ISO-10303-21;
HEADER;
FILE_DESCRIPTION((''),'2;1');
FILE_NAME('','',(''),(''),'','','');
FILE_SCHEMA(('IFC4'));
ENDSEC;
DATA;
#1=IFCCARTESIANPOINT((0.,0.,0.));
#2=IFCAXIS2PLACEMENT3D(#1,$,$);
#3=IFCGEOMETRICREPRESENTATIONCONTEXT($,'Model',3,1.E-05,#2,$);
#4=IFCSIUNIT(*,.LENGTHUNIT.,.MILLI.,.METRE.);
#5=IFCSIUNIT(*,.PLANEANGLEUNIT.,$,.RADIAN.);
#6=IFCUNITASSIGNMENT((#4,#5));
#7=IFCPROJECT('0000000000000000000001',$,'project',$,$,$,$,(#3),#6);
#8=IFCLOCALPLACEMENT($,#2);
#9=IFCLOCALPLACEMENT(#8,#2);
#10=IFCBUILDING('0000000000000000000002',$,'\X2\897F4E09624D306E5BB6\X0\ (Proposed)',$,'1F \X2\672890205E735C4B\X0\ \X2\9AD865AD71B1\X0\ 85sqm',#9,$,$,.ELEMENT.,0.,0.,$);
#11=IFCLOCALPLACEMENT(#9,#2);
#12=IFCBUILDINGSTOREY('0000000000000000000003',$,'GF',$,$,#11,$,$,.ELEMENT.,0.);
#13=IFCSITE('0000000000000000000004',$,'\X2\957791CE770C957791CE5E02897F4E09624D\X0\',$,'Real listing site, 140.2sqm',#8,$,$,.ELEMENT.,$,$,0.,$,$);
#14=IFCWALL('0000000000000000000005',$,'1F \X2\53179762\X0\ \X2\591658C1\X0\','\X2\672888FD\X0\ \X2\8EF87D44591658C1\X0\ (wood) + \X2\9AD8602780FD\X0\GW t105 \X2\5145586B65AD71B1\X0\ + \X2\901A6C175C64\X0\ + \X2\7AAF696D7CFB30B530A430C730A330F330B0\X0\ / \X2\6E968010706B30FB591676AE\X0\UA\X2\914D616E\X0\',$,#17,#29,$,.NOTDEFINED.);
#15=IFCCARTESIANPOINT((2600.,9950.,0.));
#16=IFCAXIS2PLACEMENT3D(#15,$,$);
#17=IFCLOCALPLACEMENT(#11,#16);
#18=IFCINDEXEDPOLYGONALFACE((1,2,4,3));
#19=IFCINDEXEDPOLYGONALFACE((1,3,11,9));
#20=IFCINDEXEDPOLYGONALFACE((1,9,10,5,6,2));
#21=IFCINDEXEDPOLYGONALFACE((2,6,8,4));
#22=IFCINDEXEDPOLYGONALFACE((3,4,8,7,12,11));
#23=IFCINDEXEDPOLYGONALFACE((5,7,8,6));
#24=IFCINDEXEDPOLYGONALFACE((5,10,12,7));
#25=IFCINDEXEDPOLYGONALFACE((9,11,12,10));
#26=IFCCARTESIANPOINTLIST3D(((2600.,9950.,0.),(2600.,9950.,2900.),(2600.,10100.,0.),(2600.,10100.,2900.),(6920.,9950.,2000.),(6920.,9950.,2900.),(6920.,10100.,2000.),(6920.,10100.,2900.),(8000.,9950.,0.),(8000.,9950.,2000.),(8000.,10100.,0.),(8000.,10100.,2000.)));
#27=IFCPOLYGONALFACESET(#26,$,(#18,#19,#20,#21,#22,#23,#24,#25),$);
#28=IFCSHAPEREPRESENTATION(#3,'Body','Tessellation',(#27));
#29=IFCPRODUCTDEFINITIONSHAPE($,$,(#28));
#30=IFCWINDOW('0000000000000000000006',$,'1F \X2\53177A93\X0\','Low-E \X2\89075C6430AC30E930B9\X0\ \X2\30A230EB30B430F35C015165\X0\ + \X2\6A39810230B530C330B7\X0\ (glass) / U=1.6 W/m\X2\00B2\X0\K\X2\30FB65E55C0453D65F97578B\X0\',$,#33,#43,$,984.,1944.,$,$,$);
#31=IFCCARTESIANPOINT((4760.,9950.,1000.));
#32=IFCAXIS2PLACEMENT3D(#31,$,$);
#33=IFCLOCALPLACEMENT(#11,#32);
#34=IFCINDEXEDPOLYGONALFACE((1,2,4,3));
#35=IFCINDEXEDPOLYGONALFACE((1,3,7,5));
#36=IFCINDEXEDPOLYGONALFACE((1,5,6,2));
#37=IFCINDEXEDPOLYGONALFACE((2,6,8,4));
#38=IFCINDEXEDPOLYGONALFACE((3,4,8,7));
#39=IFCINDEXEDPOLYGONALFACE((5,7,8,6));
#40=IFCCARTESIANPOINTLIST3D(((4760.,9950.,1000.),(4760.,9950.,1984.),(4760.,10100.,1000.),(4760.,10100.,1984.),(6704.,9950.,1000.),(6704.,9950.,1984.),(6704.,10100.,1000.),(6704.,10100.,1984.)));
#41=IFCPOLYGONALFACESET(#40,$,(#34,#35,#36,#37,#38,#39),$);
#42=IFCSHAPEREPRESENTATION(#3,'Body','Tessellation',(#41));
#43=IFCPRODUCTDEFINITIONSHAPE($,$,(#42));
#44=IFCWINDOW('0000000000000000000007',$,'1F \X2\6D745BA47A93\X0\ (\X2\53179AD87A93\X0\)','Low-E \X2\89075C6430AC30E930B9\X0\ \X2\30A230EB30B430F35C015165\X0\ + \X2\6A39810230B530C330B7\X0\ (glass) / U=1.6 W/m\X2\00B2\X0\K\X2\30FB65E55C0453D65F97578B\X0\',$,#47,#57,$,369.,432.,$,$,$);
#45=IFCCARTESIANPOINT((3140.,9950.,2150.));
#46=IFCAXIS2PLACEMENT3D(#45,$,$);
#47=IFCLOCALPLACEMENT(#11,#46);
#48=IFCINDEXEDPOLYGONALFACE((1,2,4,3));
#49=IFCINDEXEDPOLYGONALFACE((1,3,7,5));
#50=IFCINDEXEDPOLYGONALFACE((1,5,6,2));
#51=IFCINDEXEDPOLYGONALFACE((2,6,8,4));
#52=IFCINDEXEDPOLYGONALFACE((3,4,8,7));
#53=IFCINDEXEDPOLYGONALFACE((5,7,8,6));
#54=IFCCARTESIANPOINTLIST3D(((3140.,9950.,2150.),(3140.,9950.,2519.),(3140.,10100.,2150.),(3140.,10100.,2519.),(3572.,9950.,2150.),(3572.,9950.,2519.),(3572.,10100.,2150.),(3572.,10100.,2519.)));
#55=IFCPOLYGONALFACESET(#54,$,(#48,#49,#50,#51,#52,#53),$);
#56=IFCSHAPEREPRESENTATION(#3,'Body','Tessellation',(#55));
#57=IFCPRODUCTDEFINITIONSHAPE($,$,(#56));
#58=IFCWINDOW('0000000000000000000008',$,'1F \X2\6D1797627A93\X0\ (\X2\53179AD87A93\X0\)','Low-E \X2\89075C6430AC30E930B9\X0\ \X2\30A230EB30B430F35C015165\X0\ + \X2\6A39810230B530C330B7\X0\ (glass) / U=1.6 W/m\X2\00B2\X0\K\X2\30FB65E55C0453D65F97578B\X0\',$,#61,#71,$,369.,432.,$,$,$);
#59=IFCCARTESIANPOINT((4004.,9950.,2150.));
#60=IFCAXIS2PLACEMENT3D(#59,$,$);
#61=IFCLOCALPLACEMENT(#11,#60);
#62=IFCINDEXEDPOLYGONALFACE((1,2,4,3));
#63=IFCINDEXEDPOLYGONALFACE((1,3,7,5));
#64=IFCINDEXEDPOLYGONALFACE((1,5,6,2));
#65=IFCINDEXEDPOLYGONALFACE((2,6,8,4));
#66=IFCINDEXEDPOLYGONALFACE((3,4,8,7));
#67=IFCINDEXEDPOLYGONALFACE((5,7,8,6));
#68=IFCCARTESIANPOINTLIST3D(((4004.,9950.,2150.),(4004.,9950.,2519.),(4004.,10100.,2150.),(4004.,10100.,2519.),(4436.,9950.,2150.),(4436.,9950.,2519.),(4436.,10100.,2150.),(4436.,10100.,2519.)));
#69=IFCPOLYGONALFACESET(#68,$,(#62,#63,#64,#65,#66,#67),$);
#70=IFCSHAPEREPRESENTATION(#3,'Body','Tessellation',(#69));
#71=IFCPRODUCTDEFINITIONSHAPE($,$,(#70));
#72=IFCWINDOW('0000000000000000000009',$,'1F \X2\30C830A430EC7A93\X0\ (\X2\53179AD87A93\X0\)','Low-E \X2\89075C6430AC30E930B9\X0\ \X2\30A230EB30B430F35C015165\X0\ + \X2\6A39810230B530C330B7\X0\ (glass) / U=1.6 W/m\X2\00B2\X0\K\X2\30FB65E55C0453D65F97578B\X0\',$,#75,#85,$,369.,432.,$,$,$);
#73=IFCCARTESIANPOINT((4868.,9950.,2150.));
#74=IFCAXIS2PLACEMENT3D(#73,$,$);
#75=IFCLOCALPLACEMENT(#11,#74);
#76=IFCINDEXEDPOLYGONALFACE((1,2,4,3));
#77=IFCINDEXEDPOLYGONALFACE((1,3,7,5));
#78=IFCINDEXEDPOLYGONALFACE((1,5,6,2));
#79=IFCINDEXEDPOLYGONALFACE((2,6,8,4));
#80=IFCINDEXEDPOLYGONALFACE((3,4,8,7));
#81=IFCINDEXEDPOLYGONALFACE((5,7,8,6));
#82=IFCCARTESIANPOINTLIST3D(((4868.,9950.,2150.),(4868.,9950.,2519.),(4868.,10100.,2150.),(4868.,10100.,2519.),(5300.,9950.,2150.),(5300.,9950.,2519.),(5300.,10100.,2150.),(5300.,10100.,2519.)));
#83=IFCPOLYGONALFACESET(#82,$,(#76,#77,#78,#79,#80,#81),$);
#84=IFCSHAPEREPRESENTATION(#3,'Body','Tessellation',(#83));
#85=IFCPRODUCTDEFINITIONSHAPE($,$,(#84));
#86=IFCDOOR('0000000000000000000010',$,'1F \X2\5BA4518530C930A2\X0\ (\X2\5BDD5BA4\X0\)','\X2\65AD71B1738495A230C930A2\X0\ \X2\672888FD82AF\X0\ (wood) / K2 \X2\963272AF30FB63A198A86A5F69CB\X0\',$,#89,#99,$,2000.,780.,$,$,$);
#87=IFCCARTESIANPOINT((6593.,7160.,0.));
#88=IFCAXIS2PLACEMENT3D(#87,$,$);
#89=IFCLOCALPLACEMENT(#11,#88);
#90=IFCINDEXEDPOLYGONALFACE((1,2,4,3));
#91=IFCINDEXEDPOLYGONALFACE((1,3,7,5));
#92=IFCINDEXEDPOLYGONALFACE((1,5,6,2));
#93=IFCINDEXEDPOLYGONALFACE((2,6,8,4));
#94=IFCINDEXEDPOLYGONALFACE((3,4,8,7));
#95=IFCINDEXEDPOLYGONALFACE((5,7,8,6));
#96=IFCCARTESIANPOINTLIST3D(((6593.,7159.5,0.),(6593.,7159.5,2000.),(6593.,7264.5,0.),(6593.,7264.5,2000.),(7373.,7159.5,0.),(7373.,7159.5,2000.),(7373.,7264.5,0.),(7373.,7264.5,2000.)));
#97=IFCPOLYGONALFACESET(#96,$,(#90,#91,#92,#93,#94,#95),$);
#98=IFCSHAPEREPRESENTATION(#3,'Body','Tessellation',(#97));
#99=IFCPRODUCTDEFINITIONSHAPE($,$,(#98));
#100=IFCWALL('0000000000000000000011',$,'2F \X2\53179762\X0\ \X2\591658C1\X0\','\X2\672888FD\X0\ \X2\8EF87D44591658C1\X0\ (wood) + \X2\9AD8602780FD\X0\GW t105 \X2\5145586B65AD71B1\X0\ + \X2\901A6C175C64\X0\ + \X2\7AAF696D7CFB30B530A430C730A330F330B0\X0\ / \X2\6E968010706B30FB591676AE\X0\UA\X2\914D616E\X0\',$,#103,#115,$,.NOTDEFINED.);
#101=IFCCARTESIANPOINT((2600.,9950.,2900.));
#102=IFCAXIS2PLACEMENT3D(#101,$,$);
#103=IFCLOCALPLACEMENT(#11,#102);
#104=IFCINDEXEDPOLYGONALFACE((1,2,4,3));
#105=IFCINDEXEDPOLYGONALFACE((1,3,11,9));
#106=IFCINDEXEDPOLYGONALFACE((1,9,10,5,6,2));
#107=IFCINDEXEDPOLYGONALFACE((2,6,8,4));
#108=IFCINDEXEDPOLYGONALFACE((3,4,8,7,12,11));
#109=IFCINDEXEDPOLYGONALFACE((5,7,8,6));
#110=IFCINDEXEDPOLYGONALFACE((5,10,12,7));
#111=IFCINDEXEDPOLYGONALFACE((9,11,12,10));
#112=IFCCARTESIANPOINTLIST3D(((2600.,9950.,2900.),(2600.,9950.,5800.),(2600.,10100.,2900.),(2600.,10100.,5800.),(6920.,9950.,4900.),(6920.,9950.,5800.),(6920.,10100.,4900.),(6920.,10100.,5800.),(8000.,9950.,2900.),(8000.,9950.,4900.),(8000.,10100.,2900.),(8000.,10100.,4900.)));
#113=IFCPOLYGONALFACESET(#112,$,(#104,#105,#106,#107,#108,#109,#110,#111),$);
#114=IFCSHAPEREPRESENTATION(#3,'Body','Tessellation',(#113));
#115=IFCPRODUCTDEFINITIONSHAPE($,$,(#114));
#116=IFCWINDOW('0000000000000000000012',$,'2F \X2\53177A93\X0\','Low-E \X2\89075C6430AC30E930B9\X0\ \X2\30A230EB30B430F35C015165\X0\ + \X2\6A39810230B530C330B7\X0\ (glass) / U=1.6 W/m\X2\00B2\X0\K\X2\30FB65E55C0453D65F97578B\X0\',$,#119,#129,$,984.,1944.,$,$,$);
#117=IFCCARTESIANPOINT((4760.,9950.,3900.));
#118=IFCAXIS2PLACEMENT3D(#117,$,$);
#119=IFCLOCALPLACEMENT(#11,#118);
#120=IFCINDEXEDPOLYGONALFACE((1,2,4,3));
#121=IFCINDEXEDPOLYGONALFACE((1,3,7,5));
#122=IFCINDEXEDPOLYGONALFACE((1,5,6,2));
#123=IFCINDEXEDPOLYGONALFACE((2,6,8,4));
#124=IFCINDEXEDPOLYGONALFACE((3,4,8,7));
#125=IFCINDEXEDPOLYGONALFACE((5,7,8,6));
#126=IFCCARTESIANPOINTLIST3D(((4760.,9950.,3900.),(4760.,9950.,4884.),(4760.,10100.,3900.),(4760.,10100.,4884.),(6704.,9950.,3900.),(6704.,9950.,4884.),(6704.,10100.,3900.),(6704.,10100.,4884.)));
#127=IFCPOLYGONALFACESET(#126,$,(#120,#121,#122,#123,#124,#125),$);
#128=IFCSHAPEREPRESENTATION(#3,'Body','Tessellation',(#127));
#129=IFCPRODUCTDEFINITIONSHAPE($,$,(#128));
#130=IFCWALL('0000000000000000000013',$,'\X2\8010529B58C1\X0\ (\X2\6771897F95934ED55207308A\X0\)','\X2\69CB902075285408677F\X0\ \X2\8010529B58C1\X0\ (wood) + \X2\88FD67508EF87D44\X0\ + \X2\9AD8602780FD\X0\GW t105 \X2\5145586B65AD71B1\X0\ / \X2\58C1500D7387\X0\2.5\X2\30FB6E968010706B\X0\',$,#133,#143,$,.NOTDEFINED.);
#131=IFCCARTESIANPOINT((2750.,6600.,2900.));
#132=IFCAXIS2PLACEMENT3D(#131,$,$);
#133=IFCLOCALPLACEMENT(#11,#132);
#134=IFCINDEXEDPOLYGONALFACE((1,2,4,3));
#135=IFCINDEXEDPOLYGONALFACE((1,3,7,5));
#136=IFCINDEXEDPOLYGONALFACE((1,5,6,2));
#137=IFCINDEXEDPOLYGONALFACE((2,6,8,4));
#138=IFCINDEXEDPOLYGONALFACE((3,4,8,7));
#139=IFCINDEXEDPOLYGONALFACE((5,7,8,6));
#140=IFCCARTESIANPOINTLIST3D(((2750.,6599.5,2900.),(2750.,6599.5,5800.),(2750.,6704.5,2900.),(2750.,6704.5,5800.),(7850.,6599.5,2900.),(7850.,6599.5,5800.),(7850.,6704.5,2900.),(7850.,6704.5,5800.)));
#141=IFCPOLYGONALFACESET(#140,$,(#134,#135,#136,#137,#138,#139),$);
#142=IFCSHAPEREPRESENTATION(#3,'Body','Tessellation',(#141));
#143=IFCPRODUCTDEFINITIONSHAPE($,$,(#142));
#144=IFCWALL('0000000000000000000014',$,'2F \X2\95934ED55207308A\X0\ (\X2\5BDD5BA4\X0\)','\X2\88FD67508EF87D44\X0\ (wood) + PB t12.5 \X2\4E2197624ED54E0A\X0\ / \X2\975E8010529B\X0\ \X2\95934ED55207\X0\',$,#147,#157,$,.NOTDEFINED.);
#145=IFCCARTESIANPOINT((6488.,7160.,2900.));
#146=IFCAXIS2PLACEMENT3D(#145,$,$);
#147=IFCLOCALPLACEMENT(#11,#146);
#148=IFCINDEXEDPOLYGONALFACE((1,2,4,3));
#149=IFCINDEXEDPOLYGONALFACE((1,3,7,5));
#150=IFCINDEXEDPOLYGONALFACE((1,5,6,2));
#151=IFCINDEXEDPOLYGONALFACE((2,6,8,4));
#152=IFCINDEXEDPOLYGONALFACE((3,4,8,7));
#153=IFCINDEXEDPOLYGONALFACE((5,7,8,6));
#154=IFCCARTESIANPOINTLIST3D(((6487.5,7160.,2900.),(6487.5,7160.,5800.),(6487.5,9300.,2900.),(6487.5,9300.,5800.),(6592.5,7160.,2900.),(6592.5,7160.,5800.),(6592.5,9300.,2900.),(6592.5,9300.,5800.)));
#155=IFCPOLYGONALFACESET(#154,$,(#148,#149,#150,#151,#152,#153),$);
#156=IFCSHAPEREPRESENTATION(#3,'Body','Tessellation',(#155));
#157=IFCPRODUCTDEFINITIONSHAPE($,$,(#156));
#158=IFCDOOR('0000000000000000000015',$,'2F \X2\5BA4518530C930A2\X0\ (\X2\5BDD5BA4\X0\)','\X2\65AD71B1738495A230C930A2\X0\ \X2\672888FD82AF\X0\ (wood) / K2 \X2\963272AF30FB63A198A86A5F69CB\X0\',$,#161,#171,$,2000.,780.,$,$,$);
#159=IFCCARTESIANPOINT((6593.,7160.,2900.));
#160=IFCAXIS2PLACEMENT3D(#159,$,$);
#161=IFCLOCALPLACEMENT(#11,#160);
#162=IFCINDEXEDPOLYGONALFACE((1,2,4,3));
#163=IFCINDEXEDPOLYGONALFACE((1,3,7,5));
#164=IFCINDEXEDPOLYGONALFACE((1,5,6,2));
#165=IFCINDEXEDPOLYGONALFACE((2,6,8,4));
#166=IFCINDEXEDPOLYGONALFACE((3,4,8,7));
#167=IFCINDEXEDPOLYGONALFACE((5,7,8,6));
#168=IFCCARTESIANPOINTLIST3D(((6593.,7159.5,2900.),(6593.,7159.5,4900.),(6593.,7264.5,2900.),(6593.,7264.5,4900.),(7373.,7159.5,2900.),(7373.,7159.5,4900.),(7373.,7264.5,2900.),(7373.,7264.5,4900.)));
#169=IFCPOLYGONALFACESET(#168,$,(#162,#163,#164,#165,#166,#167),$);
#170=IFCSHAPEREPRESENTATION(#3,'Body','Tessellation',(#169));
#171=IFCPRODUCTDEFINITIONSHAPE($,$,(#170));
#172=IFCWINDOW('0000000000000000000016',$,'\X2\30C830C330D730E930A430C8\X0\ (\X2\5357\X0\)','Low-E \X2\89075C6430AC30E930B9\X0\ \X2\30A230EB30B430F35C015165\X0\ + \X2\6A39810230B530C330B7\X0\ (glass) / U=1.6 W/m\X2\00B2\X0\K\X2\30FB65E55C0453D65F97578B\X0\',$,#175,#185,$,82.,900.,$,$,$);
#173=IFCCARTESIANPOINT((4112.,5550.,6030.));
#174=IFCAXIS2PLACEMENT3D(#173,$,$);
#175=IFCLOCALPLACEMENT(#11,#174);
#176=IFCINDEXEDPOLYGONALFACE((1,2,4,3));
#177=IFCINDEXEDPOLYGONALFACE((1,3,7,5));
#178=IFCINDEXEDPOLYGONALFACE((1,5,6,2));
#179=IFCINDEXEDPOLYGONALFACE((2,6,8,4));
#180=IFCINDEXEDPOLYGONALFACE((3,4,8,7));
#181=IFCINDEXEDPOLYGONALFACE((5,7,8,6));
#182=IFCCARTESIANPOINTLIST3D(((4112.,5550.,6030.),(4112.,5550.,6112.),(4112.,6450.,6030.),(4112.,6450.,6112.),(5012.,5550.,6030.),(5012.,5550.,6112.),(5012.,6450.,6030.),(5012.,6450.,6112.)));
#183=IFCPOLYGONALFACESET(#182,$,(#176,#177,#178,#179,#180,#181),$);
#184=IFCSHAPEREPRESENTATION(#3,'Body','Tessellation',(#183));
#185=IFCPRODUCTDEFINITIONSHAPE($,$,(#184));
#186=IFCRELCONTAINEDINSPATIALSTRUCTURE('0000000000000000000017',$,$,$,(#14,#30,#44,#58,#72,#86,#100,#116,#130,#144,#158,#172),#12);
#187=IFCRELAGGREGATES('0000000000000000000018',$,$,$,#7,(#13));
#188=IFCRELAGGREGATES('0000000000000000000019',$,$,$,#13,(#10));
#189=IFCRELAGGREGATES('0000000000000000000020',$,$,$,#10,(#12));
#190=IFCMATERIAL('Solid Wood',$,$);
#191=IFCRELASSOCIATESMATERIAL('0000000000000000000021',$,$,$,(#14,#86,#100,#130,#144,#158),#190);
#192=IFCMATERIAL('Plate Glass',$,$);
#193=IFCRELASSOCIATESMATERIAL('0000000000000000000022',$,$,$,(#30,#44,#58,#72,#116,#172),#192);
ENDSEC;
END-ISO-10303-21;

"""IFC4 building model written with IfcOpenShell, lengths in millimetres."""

from ifc_helpers import new_model, si_unit, frame, frame_2d, origin, place, context, project, spatial, rectangle, extrude, material, element, fill, save


model = new_model("IFC4")

# Units and contexts
model_context = context("Model", 3, precision=1e-05, world=origin())
ifc_project = project(units=[si_unit("LENGTHUNIT", "METRE", prefix="MILLI"), si_unit("PLANEANGLEUNIT", "RADIAN")], contexts=[model_context])

# Site, building, storey
site_placement = place(None, origin())
site = spatial("IfcSite", under=ifc_project, at=site_placement, Name="長野県長野市西三才", ObjectType="Real listing site, 140.2sqm", CompositionType="ELEMENT", RefElevation=0.0)
building_placement = place(site_placement, origin())
building = spatial("IfcBuilding", under=site, at=building_placement, Name="西三才の家 (Proposed)", ObjectType="1F 木造平屋 高断熱 85sqm", CompositionType="ELEMENT", ElevationOfRefHeight=0.0, ElevationOfTerrain=0.0)
storey_placement = place(building_placement, origin())
storey = spatial("IfcBuildingStorey", under=building, at=storey_placement, Name="GF", CompositionType="ELEMENT", Elevation=0.0)

# Wall, openings, windows
ifc_material_1 = material(Name="Solid Wood")
wall_1_placement = place(storey_placement, frame((2600.0, 9950.0, 0.0)))
wall_1 = element("IfcWall", 1, at=wall_1_placement, inside=storey, material=ifc_material_1, Name="1F 北面 外壁", Description="木製 軸組外壁 (wood) + 高性能GW t105 充填断熱 + 通気層 + 窯業系サイディング / 準耐火・外皮UA配慮", PredefinedType="NOTDEFINED", context=model_context, shape_type="SweptSolid", body=[
    extrude(rectangle(XDim=5400.0, YDim=150.0, at=frame_2d((2700.0, 75.0))), frame((2600.0, 9950.0, 0.0)), (0.0, 0.0, 1.0), 2900.0),
])
opening_1_placement = place(storey_placement, frame((4760.0, 9950.0, 1000.0)))
opening_1 = element("IfcOpeningElement", 2, at=opening_1_placement, cuts=wall_1, PredefinedType="NOTDEFINED", context=model_context, shape_type="SweptSolid", body=[
    extrude(rectangle(XDim=1944.0, YDim=150.0, at=frame_2d((972.0, 75.0))), frame((4760.0, 9950.0, 1000.0)), (0.0, 0.0, 1.0), 984.0),
])
opening_2_placement = place(storey_placement, frame((3140.0, 9950.0, 2150.0)))
opening_2 = element("IfcOpeningElement", 3, at=opening_2_placement, cuts=wall_1, PredefinedType="NOTDEFINED", context=model_context, shape_type="SweptSolid", body=[
    extrude(rectangle(XDim=432.0, YDim=150.0, at=frame_2d((216.0, 75.0))), frame((3140.0, 9950.0, 2150.0)), (0.0, 0.0, 1.0), 369.0),
])
opening_3_placement = place(storey_placement, frame((4004.0, 9950.0, 2150.0)))
opening_3 = element("IfcOpeningElement", 4, at=opening_3_placement, cuts=wall_1, PredefinedType="NOTDEFINED", context=model_context, shape_type="SweptSolid", body=[
    extrude(rectangle(XDim=432.0, YDim=150.0, at=frame_2d((216.0, 75.0))), frame((4004.0, 9950.0, 2150.0)), (0.0, 0.0, 1.0), 369.0),
])
opening_4_placement = place(storey_placement, frame((4868.0, 9950.0, 2150.0)))
opening_4 = element("IfcOpeningElement", 5, at=opening_4_placement, cuts=wall_1, PredefinedType="NOTDEFINED", context=model_context, shape_type="SweptSolid", body=[
    extrude(rectangle(XDim=432.0, YDim=150.0, at=frame_2d((216.0, 75.0))), frame((4868.0, 9950.0, 2150.0)), (0.0, 0.0, 1.0), 369.0),
])
ifc_material_2 = material(Name="Plate Glass")
window_1_placement = place(storey_placement, frame((4760.0, 9950.0, 1000.0)))
window_1 = element("IfcWindow", 6, at=window_1_placement, inside=storey, material=ifc_material_2, Name="1F 北窓", Description="Low-E 複層ガラス アルゴン封入 + 樹脂サッシ (glass) / U=1.6 W/m²K・日射取得型", OverallHeight=984.0, OverallWidth=1944.0, context=model_context, shape_type="SweptSolid", body=[
    extrude(rectangle(XDim=1944.0, YDim=150.0, at=frame_2d((972.0, 75.0))), frame((4760.0, 9950.0, 1000.0)), (0.0, 0.0, 1.0), 984.0),
])
fill(opening_1, window_1)
window_2_placement = place(storey_placement, frame((3140.0, 9950.0, 2150.0)))
window_2 = element("IfcWindow", 7, at=window_2_placement, inside=storey, material=ifc_material_2, Name="1F 浴室窓 (北高窓)", Description="Low-E 複層ガラス アルゴン封入 + 樹脂サッシ (glass) / U=1.6 W/m²K・日射取得型", OverallHeight=369.0, OverallWidth=432.0, context=model_context, shape_type="SweptSolid", body=[
    extrude(rectangle(XDim=432.0, YDim=150.0, at=frame_2d((216.0, 75.0))), frame((3140.0, 9950.0, 2150.0)), (0.0, 0.0, 1.0), 369.0),
])
fill(opening_2, window_2)
window_3_placement = place(storey_placement, frame((4004.0, 9950.0, 2150.0)))
window_3 = element("IfcWindow", 8, at=window_3_placement, inside=storey, material=ifc_material_2, Name="1F 洗面窓 (北高窓)", Description="Low-E 複層ガラス アルゴン封入 + 樹脂サッシ (glass) / U=1.6 W/m²K・日射取得型", OverallHeight=369.0, OverallWidth=432.0, context=model_context, shape_type="SweptSolid", body=[
    extrude(rectangle(XDim=432.0, YDim=150.0, at=frame_2d((216.0, 75.0))), frame((4004.0, 9950.0, 2150.0)), (0.0, 0.0, 1.0), 369.0),
])
fill(opening_3, window_3)
window_4_placement = place(storey_placement, frame((4868.0, 9950.0, 2150.0)))
window_4 = element("IfcWindow", 9, at=window_4_placement, inside=storey, material=ifc_material_2, Name="1F トイレ窓 (北高窓)", Description="Low-E 複層ガラス アルゴン封入 + 樹脂サッシ (glass) / U=1.6 W/m²K・日射取得型", OverallHeight=369.0, OverallWidth=432.0, context=model_context, shape_type="SweptSolid", body=[
    extrude(rectangle(XDim=432.0, YDim=150.0, at=frame_2d((216.0, 75.0))), frame((4868.0, 9950.0, 2150.0)), (0.0, 0.0, 1.0), 369.0),
])
fill(opening_4, window_4)

# Door
door_1_placement = place(storey_placement, frame((6593.0, 7160.0, 0.0)))
element("IfcDoor", 10, at=door_1_placement, inside=storey, material=ifc_material_1, Name="1F 室内ドア (寝室)", Description="断熱玄関ドア 木製芯 (wood) / K2 防犯・採風機構", OverallHeight=2000.0, OverallWidth=780.0, context=model_context, shape_type="SweptSolid", body=[
    extrude(rectangle(XDim=780.0, YDim=105.0, at=frame_2d((390.0, 52.0))), frame((6593.0, 7160.0, 0.0)), (0.0, 0.0, 1.0), 2000.0),
])

# Wall, opening, window
wall_2_placement = place(storey_placement, frame((2600.0, 9950.0, 2900.0)))
wall_2 = element("IfcWall", 11, at=wall_2_placement, inside=storey, material=ifc_material_1, Name="2F 北面 外壁", Description="木製 軸組外壁 (wood) + 高性能GW t105 充填断熱 + 通気層 + 窯業系サイディング / 準耐火・外皮UA配慮", PredefinedType="NOTDEFINED", context=model_context, shape_type="SweptSolid", body=[
    extrude(rectangle(XDim=5400.0, YDim=150.0, at=frame_2d((2700.0, 75.0))), frame((2600.0, 9950.0, 2900.0)), (0.0, 0.0, 1.0), 2900.0),
])
opening_5_placement = place(storey_placement, frame((4760.0, 9950.0, 3900.0)))
opening_5 = element("IfcOpeningElement", 12, at=opening_5_placement, cuts=wall_2, PredefinedType="NOTDEFINED", context=model_context, shape_type="SweptSolid", body=[
    extrude(rectangle(XDim=1944.0, YDim=150.0, at=frame_2d((972.0, 75.0))), frame((4760.0, 9950.0, 3900.0)), (0.0, 0.0, 1.0), 984.0),
])
window_5_placement = place(storey_placement, frame((4760.0, 9950.0, 3900.0)))
window_5 = element("IfcWindow", 13, at=window_5_placement, inside=storey, material=ifc_material_2, Name="2F 北窓", Description="Low-E 複層ガラス アルゴン封入 + 樹脂サッシ (glass) / U=1.6 W/m²K・日射取得型", OverallHeight=984.0, OverallWidth=1944.0, context=model_context, shape_type="SweptSolid", body=[
    extrude(rectangle(XDim=1944.0, YDim=150.0, at=frame_2d((972.0, 75.0))), frame((4760.0, 9950.0, 3900.0)), (0.0, 0.0, 1.0), 984.0),
])
fill(opening_5, window_5)

# Walls
wall_3_placement = place(storey_placement, frame((2750.0, 6600.0, 2900.0)))
element("IfcWall", 14, at=wall_3_placement, inside=storey, material=ifc_material_1, Name="耐力壁 (東西間仕切り)", Description="構造用合板 耐力壁 (wood) + 製材軸組 + 高性能GW t105 充填断熱 / 壁倍率2.5・準耐火", PredefinedType="NOTDEFINED", context=model_context, shape_type="SweptSolid", body=[
    extrude(rectangle(XDim=5100.0, YDim=105.0, at=frame_2d((2550.0, 52.0))), frame((2750.0, 6600.0, 2900.0)), (0.0, 0.0, 1.0), 2900.0),
])
wall_4_placement = place(storey_placement, frame((6488.0, 7160.0, 2900.0)))
element("IfcWall", 15, at=wall_4_placement, inside=storey, material=ifc_material_1, Name="2F 間仕切り (寝室)", Description="製材軸組 (wood) + PB t12.5 両面仕上 / 非耐力 間仕切", PredefinedType="NOTDEFINED", context=model_context, shape_type="SweptSolid", body=[
    extrude(rectangle(XDim=105.0, YDim=2140.0, at=frame_2d((52.0, 1070.0))), frame((6488.0, 7160.0, 2900.0)), (0.0, 0.0, 1.0), 2900.0),
])

# Door
door_2_placement = place(storey_placement, frame((6593.0, 7160.0, 2900.0)))
element("IfcDoor", 16, at=door_2_placement, inside=storey, material=ifc_material_1, Name="2F 室内ドア (寝室)", Description="断熱玄関ドア 木製芯 (wood) / K2 防犯・採風機構", OverallHeight=2000.0, OverallWidth=780.0, context=model_context, shape_type="SweptSolid", body=[
    extrude(rectangle(XDim=780.0, YDim=105.0, at=frame_2d((390.0, 52.0))), frame((6593.0, 7160.0, 2900.0)), (0.0, 0.0, 1.0), 2000.0),
])

# Window
window_6_placement = place(storey_placement, frame((4112.0, 5550.0, 6030.0)))
element("IfcWindow", 17, at=window_6_placement, inside=storey, material=ifc_material_2, Name="トップライト (南)", Description="Low-E 複層ガラス アルゴン封入 + 樹脂サッシ (glass) / U=1.6 W/m²K・日射取得型", OverallHeight=82.0, OverallWidth=900.0, context=model_context, shape_type="SweptSolid", body=[
    extrude(rectangle(XDim=900.0, YDim=900.0, at=frame_2d((450.0, 450.0))), frame((4112.0, 5550.0, 6030.0)), (0.0, 0.0, 1.0), 82.0),
])

save(model, "model.ifc")
